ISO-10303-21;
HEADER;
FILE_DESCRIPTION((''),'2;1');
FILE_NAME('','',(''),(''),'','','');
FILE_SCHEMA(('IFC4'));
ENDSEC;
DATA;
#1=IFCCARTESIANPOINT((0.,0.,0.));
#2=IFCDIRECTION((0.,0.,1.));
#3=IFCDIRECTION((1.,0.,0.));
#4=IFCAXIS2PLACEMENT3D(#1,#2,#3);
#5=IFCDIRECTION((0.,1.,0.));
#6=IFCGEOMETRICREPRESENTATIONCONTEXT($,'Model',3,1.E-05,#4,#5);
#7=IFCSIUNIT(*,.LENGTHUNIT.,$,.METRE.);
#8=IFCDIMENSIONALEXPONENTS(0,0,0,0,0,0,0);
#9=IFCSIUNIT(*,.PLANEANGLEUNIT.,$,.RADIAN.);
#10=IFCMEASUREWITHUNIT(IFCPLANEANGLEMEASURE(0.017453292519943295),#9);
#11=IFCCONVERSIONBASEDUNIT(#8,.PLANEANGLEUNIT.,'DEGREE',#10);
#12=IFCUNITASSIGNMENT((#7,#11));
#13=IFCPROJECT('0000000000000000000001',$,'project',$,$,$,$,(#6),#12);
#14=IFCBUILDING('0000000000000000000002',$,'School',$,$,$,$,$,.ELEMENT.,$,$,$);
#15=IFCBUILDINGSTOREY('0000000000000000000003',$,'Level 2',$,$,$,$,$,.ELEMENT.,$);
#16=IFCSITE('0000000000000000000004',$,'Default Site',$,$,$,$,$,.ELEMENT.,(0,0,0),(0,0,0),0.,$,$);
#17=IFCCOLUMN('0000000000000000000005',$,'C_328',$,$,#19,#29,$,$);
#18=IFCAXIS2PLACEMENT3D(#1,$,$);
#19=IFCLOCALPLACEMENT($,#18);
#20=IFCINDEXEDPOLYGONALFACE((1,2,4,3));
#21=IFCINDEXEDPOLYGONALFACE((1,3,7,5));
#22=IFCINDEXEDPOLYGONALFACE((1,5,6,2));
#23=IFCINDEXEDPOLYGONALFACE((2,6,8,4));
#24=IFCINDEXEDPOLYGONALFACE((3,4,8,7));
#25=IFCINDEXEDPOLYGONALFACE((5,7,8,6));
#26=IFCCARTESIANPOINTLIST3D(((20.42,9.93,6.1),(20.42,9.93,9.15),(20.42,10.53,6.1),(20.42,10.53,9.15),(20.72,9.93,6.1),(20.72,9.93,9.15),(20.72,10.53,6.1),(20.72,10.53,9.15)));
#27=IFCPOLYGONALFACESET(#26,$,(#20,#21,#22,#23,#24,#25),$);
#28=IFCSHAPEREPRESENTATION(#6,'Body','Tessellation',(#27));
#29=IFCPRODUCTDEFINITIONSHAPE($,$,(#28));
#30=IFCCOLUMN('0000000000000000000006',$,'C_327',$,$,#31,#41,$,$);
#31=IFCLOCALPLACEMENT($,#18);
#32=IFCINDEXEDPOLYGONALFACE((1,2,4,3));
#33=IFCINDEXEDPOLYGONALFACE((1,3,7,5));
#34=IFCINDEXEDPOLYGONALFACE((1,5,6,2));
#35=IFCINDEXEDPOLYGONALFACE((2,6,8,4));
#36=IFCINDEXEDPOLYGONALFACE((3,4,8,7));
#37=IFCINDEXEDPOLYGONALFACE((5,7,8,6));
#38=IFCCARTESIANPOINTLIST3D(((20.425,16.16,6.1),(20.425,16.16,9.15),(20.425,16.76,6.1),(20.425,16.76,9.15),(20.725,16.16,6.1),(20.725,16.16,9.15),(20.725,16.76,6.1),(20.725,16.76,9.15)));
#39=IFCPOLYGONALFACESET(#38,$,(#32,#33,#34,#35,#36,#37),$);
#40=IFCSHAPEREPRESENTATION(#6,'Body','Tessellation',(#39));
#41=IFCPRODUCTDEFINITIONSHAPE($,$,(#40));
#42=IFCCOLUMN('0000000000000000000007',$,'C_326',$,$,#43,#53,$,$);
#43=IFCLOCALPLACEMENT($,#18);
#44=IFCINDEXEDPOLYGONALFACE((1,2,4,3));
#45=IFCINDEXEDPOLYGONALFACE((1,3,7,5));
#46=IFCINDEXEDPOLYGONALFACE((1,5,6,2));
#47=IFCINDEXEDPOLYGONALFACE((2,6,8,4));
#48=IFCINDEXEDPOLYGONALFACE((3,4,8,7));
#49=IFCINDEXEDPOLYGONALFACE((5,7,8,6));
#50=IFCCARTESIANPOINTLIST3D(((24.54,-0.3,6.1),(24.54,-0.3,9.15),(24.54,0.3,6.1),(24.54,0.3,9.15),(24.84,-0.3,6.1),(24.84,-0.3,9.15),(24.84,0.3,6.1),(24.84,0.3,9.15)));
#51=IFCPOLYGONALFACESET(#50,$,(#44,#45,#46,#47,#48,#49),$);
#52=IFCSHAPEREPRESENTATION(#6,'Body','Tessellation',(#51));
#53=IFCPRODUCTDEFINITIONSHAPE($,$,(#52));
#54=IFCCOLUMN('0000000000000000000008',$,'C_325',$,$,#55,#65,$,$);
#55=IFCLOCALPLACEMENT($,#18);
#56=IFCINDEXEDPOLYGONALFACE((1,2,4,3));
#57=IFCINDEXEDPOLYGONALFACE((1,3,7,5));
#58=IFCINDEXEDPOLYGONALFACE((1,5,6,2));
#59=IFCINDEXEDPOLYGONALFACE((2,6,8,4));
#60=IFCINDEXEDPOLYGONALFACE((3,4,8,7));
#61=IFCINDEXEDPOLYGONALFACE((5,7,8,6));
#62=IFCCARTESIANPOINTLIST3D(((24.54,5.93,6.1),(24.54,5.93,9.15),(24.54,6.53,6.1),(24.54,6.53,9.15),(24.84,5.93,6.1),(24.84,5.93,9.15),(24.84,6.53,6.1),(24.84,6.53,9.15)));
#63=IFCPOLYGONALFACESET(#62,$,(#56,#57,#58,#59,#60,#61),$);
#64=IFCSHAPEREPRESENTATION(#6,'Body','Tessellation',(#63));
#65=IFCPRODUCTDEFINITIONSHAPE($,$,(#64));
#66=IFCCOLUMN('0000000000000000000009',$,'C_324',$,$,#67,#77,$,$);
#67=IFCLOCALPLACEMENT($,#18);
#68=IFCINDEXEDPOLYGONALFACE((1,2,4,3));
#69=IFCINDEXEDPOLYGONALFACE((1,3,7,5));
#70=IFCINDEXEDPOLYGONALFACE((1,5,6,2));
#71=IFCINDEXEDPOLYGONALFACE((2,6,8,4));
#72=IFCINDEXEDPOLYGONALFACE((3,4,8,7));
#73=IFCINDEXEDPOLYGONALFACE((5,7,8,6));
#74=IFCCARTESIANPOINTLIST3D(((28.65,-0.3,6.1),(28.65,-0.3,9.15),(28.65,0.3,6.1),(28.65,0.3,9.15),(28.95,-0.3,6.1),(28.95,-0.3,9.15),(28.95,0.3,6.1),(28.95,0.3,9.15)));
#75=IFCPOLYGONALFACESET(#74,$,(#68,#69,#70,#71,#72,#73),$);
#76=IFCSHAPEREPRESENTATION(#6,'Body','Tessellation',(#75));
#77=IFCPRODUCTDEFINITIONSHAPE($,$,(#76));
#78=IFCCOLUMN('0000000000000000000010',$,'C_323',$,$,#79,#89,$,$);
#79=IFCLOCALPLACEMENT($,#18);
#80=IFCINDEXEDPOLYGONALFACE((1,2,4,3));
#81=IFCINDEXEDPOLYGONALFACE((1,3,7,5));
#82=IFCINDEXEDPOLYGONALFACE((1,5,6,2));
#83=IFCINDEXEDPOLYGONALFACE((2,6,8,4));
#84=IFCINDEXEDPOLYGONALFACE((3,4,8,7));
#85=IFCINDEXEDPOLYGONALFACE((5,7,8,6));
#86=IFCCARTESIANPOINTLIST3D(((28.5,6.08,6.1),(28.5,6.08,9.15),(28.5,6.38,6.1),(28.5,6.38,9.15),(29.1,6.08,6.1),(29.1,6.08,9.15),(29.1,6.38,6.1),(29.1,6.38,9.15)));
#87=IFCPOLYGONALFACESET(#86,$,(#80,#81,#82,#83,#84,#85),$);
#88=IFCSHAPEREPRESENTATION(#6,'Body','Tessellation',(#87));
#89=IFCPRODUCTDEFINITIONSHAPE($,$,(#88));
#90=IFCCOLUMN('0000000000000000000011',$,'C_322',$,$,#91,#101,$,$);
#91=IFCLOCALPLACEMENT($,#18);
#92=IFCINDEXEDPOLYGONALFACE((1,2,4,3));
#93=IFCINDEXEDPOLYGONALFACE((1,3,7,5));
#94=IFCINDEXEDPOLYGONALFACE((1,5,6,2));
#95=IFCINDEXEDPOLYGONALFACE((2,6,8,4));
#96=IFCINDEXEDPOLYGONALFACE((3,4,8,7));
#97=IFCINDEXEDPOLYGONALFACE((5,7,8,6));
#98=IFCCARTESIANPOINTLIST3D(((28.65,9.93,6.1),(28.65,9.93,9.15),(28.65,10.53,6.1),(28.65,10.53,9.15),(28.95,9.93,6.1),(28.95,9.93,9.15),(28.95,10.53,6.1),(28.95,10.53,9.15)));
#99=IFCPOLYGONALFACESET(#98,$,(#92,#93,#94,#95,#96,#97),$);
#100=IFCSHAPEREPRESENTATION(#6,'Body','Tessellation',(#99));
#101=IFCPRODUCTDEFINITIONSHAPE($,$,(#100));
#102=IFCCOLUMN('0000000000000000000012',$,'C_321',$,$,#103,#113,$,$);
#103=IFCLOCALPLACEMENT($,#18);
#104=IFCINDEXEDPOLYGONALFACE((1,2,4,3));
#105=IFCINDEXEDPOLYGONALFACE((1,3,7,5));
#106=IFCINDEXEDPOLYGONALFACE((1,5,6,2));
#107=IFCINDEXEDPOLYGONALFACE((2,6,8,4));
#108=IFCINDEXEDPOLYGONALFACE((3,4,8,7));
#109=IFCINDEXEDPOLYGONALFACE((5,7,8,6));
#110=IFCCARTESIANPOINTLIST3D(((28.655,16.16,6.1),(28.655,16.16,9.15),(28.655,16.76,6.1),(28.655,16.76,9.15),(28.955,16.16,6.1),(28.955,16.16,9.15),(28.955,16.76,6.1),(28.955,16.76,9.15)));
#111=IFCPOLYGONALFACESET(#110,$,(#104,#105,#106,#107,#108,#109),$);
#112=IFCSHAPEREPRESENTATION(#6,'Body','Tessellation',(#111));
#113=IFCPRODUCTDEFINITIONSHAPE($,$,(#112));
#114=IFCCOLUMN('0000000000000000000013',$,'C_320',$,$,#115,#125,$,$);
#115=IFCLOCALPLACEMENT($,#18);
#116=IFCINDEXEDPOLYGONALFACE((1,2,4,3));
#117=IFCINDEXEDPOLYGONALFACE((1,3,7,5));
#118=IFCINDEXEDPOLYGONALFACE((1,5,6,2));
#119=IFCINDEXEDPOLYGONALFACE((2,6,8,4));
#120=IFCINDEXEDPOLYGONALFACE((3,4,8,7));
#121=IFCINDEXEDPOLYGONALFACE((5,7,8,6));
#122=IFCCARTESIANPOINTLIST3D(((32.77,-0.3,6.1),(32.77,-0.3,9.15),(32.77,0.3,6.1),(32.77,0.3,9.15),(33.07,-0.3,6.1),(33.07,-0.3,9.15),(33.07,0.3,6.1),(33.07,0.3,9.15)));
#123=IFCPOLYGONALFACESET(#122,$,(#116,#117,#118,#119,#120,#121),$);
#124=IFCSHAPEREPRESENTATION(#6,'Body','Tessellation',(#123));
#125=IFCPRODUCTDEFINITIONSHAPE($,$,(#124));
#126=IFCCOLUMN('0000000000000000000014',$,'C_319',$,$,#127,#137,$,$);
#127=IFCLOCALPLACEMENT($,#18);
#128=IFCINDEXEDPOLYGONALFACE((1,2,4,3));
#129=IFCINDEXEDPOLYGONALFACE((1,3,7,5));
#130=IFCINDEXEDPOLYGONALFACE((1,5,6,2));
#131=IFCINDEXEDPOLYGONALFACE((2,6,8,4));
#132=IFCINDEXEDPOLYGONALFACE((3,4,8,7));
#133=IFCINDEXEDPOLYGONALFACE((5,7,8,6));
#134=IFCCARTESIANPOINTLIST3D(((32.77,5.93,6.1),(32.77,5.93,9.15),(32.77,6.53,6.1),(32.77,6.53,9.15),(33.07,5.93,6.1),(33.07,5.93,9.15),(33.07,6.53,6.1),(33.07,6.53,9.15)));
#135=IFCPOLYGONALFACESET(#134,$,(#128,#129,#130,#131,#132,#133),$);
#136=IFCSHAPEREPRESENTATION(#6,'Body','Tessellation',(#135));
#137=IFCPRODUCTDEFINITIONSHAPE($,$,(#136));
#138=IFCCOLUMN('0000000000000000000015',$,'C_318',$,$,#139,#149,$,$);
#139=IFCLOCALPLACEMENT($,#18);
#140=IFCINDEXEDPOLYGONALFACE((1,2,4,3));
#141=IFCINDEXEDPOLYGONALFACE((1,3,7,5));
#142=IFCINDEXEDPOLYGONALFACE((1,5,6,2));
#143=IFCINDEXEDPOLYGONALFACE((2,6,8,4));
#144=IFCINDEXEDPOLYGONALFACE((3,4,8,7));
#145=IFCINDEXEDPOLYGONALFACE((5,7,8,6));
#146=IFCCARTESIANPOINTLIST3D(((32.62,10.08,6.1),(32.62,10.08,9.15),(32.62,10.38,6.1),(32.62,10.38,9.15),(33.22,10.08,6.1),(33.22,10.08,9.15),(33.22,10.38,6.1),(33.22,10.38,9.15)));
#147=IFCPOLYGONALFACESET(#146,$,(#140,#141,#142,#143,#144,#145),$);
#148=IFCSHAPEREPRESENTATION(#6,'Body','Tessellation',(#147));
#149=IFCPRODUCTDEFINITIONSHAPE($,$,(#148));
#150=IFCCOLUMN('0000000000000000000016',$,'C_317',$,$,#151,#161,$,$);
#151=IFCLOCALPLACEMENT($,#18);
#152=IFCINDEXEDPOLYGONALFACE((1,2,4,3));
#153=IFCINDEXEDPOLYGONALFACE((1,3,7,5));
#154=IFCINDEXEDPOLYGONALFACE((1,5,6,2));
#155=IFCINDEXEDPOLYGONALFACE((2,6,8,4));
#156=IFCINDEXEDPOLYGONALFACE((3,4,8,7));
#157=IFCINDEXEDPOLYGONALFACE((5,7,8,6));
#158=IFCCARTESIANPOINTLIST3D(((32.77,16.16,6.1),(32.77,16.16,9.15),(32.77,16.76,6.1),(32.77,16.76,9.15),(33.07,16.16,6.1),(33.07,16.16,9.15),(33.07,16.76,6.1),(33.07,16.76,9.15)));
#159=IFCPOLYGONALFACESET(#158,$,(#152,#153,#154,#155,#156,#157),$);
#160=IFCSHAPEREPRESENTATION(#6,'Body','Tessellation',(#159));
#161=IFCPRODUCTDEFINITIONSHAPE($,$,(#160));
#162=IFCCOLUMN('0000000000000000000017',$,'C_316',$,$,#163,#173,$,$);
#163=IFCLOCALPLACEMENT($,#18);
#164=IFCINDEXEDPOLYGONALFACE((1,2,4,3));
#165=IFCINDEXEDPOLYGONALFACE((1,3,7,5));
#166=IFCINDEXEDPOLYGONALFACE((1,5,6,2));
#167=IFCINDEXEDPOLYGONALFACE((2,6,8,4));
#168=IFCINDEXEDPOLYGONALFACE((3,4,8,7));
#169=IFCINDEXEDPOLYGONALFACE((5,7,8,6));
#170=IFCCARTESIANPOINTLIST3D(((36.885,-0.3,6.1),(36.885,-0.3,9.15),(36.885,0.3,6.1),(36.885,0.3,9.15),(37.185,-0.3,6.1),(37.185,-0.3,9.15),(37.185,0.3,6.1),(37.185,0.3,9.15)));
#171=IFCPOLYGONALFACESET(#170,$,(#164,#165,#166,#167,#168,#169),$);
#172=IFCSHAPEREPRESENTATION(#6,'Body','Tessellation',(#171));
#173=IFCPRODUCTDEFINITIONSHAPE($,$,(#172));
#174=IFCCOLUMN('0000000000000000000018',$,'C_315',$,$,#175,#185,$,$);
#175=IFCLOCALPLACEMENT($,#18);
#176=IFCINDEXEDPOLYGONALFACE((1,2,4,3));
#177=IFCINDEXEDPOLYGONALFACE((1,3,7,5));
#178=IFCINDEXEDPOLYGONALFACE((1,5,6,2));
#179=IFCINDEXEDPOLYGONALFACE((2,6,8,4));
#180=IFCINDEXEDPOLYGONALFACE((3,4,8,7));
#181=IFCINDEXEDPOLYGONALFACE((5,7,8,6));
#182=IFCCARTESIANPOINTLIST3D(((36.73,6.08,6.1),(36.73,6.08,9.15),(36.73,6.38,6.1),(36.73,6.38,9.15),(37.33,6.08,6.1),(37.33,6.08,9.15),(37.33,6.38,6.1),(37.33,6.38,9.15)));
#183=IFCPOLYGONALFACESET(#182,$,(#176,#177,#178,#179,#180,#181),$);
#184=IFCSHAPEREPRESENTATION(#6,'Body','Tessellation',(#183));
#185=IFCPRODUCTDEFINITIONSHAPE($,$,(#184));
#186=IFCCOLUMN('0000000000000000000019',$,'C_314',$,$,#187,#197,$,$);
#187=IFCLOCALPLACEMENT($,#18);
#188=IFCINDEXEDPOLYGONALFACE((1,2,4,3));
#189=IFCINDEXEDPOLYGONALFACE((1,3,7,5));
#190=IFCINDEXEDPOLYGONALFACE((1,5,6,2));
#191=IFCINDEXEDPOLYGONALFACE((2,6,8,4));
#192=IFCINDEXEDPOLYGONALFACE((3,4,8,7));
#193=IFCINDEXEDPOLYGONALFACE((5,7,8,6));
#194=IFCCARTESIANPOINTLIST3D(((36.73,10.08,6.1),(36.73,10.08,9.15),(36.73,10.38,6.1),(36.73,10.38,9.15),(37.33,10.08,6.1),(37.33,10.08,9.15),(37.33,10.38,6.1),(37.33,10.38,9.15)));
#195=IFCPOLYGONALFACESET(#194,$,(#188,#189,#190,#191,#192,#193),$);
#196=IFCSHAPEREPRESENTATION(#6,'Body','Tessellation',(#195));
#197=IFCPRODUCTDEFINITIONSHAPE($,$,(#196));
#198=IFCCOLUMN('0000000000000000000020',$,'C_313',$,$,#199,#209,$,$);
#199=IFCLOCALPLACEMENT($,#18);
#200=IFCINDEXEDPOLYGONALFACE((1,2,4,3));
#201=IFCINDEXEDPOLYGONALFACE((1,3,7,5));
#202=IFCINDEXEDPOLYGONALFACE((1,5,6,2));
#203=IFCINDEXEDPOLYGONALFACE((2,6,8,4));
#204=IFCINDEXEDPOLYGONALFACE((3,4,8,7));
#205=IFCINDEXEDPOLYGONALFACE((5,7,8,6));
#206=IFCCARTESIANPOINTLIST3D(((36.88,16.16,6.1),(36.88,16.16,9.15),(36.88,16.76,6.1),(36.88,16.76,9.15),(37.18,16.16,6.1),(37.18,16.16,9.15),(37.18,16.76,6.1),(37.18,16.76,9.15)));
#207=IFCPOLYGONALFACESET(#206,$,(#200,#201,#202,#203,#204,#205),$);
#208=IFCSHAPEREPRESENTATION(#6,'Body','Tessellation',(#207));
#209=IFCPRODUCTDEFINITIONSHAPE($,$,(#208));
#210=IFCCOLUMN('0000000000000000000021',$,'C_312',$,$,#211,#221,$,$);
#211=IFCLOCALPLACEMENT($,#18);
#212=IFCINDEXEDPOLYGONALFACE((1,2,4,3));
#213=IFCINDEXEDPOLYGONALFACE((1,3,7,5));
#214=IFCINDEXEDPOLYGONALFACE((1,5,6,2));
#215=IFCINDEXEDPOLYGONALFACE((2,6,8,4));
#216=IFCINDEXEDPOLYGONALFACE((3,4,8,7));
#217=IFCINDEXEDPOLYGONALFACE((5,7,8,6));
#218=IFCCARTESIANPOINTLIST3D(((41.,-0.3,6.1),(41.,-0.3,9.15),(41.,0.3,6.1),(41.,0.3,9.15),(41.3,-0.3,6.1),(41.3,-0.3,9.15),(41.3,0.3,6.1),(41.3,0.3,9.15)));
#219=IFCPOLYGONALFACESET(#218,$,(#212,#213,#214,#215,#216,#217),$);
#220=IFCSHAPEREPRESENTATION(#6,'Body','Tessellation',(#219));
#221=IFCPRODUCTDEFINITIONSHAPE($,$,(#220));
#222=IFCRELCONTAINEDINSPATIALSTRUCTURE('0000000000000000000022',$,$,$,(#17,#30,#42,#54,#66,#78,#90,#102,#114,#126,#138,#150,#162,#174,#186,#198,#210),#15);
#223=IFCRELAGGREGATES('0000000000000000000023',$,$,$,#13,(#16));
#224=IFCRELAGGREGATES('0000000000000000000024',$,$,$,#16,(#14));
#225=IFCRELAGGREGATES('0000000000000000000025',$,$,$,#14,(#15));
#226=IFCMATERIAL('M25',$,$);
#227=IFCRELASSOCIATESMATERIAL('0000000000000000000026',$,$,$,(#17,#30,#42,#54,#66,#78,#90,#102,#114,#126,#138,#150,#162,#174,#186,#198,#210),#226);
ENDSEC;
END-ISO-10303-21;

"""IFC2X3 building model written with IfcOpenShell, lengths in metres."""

from ifc_helpers import new_model, entity, si_unit, converted_unit, direction, frame, frame_2d, origin_with_axes, place, context, project, spatial, rectangle, extrude, material, element, save


model = new_model("IFC2X3")

# Units and contexts
model_context = context("Model", 3, precision=1e-05, world=origin_with_axes(), true_north=direction((0.0, 1.0, 0.0)))
ifc_project = project(units=[si_unit("LENGTHUNIT", "METRE"), converted_unit("PLANEANGLEUNIT", "DEGREE", entity("IfcPlaneAngleMeasure", 0.017453292519943295), si_unit("PLANEANGLEUNIT", "RADIAN"), dimensions=[0, 0, 0, 0, 0, 0, 0])], contexts=[model_context])

# Site, building, storey
site = spatial("IfcSite", under=ifc_project, Name="Default Site", CompositionType="ELEMENT", RefLatitude=(0, 0, 0), RefLongitude=(0, 0, 0), RefElevation=0.0)
building = spatial("IfcBuilding", under=site, Name="School", CompositionType="ELEMENT")
storey = spatial("IfcBuildingStorey", under=building, Name="Level 2", CompositionType="ELEMENT")

# Columns
ifc_material = material(Name="M25")
placement = place(None, origin_with_axes())
element("IfcColumn", 1, at=placement, inside=storey, material=ifc_material, Name="C_328", context=model_context, shape_type="SweptSolid", body=[
    extrude(rectangle(XDim=0.3, YDim=0.6, at=frame_2d((0.0, 0.0), x_axis=(1.0, 0.0, 0.0))), frame((20.57, 10.23, 6.1), z_axis=(0.0, 0.0, 1.0), x_axis=(1.0, 0.0, 0.0)), (0.0, 0.0, 1.0), 3.05),
])
element("IfcColumn", 2, at=placement, inside=storey, material=ifc_material, Name="C_327", context=model_context, shape_type="SweptSolid", body=[
    extrude(rectangle(XDim=0.3, YDim=0.6, at=frame_2d((0.0, 0.0), x_axis=(1.0, 0.0, 0.0))), frame((20.575, 16.46, 6.1), z_axis=(0.0, 0.0, 1.0), x_axis=(1.0, 0.0, 0.0)), (0.0, 0.0, 1.0), 3.05),
])
element("IfcColumn", 3, at=placement, inside=storey, material=ifc_material, Name="C_326", context=model_context, shape_type="SweptSolid", body=[
    extrude(rectangle(XDim=0.3, YDim=0.6, at=frame_2d((0.0, 0.0), x_axis=(1.0, 0.0, 0.0))), frame((24.69, 0.0, 6.1), z_axis=(0.0, 0.0, 1.0), x_axis=(1.0, 0.0, 0.0)), (0.0, 0.0, 1.0), 3.05),
])
element("IfcColumn", 4, at=placement, inside=storey, material=ifc_material, Name="C_325", context=model_context, shape_type="SweptSolid", body=[
    extrude(rectangle(XDim=0.3, YDim=0.6, at=frame_2d((0.0, 0.0), x_axis=(1.0, 0.0, 0.0))), frame((24.69, 6.23, 6.1), z_axis=(0.0, 0.0, 1.0), x_axis=(1.0, 0.0, 0.0)), (0.0, 0.0, 1.0), 3.05),
])
element("IfcColumn", 5, at=placement, inside=storey, material=ifc_material, Name="C_324", context=model_context, shape_type="SweptSolid", body=[
    extrude(rectangle(XDim=0.3, YDim=0.6, at=frame_2d((0.0, 0.0), x_axis=(1.0, 0.0, 0.0))), frame((28.8, 0.0, 6.1), z_axis=(0.0, 0.0, 1.0), x_axis=(1.0, 0.0, 0.0)), (0.0, 0.0, 1.0), 3.05),
])
element("IfcColumn", 6, at=placement, inside=storey, material=ifc_material, Name="C_323", context=model_context, shape_type="SweptSolid", body=[
    extrude(rectangle(XDim=0.6, YDim=0.3, at=frame_2d((0.0, 0.0), x_axis=(1.0, 0.0, 0.0))), frame((28.8, 6.23, 6.1), z_axis=(0.0, 0.0, 1.0), x_axis=(1.0, 0.0, 0.0)), (0.0, 0.0, 1.0), 3.05),
])
element("IfcColumn", 7, at=placement, inside=storey, material=ifc_material, Name="C_322", context=model_context, shape_type="SweptSolid", body=[
    extrude(rectangle(XDim=0.3, YDim=0.6, at=frame_2d((0.0, 0.0), x_axis=(1.0, 0.0, 0.0))), frame((28.8, 10.23, 6.1), z_axis=(0.0, 0.0, 1.0), x_axis=(1.0, 0.0, 0.0)), (0.0, 0.0, 1.0), 3.05),
])
element("IfcColumn", 8, at=placement, inside=storey, material=ifc_material, Name="C_321", context=model_context, shape_type="SweptSolid", body=[
    extrude(rectangle(XDim=0.3, YDim=0.6, at=frame_2d((0.0, 0.0), x_axis=(1.0, 0.0, 0.0))), frame((28.805, 16.46, 6.1), z_axis=(0.0, 0.0, 1.0), x_axis=(1.0, 0.0, 0.0)), (0.0, 0.0, 1.0), 3.05),
])
element("IfcColumn", 9, at=placement, inside=storey, material=ifc_material, Name="C_320", context=model_context, shape_type="SweptSolid", body=[
    extrude(rectangle(XDim=0.3, YDim=0.6, at=frame_2d((0.0, 0.0), x_axis=(1.0, 0.0, 0.0))), frame((32.92, 0.0, 6.1), z_axis=(0.0, 0.0, 1.0), x_axis=(1.0, 0.0, 0.0)), (0.0, 0.0, 1.0), 3.05),
])
element("IfcColumn", 10, at=placement, inside=storey, material=ifc_material, Name="C_319", context=model_context, shape_type="SweptSolid", body=[
    extrude(rectangle(XDim=0.3, YDim=0.6, at=frame_2d((0.0, 0.0), x_axis=(1.0, 0.0, 0.0))), frame((32.92, 6.23, 6.1), z_axis=(0.0, 0.0, 1.0), x_axis=(1.0, 0.0, 0.0)), (0.0, 0.0, 1.0), 3.05),
])
element("IfcColumn", 11, at=placement, inside=storey, material=ifc_material, Name="C_318", context=model_context, shape_type="SweptSolid", body=[
    extrude(rectangle(XDim=0.6, YDim=0.3, at=frame_2d((0.0, 0.0), x_axis=(1.0, 0.0, 0.0))), frame((32.92, 10.23, 6.1), z_axis=(0.0, 0.0, 1.0), x_axis=(1.0, 0.0, 0.0)), (0.0, 0.0, 1.0), 3.05),
])
element("IfcColumn", 12, at=placement, inside=storey, material=ifc_material, Name="C_317", context=model_context, shape_type="SweptSolid", body=[
    extrude(rectangle(XDim=0.3, YDim=0.6, at=frame_2d((0.0, 0.0), x_axis=(1.0, 0.0, 0.0))), frame((32.92, 16.46, 6.1), z_axis=(0.0, 0.0, 1.0), x_axis=(1.0, 0.0, 0.0)), (0.0, 0.0, 1.0), 3.05),
])
element("IfcColumn", 13, at=placement, inside=storey, material=ifc_material, Name="C_316", context=model_context, shape_type="SweptSolid", body=[
    extrude(rectangle(XDim=0.3, YDim=0.6, at=frame_2d((0.0, 0.0), x_axis=(1.0, 0.0, 0.0))), frame((37.035, 0.0, 6.1), z_axis=(0.0, 0.0, 1.0), x_axis=(1.0, 0.0, 0.0)), (0.0, 0.0, 1.0), 3.05),
])
element("IfcColumn", 14, at=placement, inside=storey, material=ifc_material, Name="C_315", context=model_context, shape_type="SweptSolid", body=[
    extrude(rectangle(XDim=0.6, YDim=0.3, at=frame_2d((0.0, 0.0), x_axis=(1.0, 0.0, 0.0))), frame((37.03, 6.23, 6.1), z_axis=(0.0, 0.0, 1.0), x_axis=(1.0, 0.0, 0.0)), (0.0, 0.0, 1.0), 3.05),
])
element("IfcColumn", 15, at=placement, inside=storey, material=ifc_material, Name="C_314", context=model_context, shape_type="SweptSolid", body=[
    extrude(rectangle(XDim=0.6, YDim=0.3, at=frame_2d((0.0, 0.0), x_axis=(1.0, 0.0, 0.0))), frame((37.03, 10.23, 6.1), z_axis=(0.0, 0.0, 1.0), x_axis=(1.0, 0.0, 0.0)), (0.0, 0.0, 1.0), 3.05),
])
element("IfcColumn", 16, at=placement, inside=storey, material=ifc_material, Name="C_313", context=model_context, shape_type="SweptSolid", body=[
    extrude(rectangle(XDim=0.3, YDim=0.6, at=frame_2d((0.0, 0.0), x_axis=(1.0, 0.0, 0.0))), frame((37.03, 16.46, 6.1), z_axis=(0.0, 0.0, 1.0), x_axis=(1.0, 0.0, 0.0)), (0.0, 0.0, 1.0), 3.05),
])
element("IfcColumn", 17, at=placement, inside=storey, material=ifc_material, Name="C_312", context=model_context, shape_type="SweptSolid", body=[
    extrude(rectangle(XDim=0.3, YDim=0.6, at=frame_2d((0.0, 0.0), x_axis=(1.0, 0.0, 0.0))), frame((41.15, 0.0, 6.1), z_axis=(0.0, 0.0, 1.0), x_axis=(1.0, 0.0, 0.0)), (0.0, 0.0, 1.0), 3.05),
])

save(model, "model.ifc")
